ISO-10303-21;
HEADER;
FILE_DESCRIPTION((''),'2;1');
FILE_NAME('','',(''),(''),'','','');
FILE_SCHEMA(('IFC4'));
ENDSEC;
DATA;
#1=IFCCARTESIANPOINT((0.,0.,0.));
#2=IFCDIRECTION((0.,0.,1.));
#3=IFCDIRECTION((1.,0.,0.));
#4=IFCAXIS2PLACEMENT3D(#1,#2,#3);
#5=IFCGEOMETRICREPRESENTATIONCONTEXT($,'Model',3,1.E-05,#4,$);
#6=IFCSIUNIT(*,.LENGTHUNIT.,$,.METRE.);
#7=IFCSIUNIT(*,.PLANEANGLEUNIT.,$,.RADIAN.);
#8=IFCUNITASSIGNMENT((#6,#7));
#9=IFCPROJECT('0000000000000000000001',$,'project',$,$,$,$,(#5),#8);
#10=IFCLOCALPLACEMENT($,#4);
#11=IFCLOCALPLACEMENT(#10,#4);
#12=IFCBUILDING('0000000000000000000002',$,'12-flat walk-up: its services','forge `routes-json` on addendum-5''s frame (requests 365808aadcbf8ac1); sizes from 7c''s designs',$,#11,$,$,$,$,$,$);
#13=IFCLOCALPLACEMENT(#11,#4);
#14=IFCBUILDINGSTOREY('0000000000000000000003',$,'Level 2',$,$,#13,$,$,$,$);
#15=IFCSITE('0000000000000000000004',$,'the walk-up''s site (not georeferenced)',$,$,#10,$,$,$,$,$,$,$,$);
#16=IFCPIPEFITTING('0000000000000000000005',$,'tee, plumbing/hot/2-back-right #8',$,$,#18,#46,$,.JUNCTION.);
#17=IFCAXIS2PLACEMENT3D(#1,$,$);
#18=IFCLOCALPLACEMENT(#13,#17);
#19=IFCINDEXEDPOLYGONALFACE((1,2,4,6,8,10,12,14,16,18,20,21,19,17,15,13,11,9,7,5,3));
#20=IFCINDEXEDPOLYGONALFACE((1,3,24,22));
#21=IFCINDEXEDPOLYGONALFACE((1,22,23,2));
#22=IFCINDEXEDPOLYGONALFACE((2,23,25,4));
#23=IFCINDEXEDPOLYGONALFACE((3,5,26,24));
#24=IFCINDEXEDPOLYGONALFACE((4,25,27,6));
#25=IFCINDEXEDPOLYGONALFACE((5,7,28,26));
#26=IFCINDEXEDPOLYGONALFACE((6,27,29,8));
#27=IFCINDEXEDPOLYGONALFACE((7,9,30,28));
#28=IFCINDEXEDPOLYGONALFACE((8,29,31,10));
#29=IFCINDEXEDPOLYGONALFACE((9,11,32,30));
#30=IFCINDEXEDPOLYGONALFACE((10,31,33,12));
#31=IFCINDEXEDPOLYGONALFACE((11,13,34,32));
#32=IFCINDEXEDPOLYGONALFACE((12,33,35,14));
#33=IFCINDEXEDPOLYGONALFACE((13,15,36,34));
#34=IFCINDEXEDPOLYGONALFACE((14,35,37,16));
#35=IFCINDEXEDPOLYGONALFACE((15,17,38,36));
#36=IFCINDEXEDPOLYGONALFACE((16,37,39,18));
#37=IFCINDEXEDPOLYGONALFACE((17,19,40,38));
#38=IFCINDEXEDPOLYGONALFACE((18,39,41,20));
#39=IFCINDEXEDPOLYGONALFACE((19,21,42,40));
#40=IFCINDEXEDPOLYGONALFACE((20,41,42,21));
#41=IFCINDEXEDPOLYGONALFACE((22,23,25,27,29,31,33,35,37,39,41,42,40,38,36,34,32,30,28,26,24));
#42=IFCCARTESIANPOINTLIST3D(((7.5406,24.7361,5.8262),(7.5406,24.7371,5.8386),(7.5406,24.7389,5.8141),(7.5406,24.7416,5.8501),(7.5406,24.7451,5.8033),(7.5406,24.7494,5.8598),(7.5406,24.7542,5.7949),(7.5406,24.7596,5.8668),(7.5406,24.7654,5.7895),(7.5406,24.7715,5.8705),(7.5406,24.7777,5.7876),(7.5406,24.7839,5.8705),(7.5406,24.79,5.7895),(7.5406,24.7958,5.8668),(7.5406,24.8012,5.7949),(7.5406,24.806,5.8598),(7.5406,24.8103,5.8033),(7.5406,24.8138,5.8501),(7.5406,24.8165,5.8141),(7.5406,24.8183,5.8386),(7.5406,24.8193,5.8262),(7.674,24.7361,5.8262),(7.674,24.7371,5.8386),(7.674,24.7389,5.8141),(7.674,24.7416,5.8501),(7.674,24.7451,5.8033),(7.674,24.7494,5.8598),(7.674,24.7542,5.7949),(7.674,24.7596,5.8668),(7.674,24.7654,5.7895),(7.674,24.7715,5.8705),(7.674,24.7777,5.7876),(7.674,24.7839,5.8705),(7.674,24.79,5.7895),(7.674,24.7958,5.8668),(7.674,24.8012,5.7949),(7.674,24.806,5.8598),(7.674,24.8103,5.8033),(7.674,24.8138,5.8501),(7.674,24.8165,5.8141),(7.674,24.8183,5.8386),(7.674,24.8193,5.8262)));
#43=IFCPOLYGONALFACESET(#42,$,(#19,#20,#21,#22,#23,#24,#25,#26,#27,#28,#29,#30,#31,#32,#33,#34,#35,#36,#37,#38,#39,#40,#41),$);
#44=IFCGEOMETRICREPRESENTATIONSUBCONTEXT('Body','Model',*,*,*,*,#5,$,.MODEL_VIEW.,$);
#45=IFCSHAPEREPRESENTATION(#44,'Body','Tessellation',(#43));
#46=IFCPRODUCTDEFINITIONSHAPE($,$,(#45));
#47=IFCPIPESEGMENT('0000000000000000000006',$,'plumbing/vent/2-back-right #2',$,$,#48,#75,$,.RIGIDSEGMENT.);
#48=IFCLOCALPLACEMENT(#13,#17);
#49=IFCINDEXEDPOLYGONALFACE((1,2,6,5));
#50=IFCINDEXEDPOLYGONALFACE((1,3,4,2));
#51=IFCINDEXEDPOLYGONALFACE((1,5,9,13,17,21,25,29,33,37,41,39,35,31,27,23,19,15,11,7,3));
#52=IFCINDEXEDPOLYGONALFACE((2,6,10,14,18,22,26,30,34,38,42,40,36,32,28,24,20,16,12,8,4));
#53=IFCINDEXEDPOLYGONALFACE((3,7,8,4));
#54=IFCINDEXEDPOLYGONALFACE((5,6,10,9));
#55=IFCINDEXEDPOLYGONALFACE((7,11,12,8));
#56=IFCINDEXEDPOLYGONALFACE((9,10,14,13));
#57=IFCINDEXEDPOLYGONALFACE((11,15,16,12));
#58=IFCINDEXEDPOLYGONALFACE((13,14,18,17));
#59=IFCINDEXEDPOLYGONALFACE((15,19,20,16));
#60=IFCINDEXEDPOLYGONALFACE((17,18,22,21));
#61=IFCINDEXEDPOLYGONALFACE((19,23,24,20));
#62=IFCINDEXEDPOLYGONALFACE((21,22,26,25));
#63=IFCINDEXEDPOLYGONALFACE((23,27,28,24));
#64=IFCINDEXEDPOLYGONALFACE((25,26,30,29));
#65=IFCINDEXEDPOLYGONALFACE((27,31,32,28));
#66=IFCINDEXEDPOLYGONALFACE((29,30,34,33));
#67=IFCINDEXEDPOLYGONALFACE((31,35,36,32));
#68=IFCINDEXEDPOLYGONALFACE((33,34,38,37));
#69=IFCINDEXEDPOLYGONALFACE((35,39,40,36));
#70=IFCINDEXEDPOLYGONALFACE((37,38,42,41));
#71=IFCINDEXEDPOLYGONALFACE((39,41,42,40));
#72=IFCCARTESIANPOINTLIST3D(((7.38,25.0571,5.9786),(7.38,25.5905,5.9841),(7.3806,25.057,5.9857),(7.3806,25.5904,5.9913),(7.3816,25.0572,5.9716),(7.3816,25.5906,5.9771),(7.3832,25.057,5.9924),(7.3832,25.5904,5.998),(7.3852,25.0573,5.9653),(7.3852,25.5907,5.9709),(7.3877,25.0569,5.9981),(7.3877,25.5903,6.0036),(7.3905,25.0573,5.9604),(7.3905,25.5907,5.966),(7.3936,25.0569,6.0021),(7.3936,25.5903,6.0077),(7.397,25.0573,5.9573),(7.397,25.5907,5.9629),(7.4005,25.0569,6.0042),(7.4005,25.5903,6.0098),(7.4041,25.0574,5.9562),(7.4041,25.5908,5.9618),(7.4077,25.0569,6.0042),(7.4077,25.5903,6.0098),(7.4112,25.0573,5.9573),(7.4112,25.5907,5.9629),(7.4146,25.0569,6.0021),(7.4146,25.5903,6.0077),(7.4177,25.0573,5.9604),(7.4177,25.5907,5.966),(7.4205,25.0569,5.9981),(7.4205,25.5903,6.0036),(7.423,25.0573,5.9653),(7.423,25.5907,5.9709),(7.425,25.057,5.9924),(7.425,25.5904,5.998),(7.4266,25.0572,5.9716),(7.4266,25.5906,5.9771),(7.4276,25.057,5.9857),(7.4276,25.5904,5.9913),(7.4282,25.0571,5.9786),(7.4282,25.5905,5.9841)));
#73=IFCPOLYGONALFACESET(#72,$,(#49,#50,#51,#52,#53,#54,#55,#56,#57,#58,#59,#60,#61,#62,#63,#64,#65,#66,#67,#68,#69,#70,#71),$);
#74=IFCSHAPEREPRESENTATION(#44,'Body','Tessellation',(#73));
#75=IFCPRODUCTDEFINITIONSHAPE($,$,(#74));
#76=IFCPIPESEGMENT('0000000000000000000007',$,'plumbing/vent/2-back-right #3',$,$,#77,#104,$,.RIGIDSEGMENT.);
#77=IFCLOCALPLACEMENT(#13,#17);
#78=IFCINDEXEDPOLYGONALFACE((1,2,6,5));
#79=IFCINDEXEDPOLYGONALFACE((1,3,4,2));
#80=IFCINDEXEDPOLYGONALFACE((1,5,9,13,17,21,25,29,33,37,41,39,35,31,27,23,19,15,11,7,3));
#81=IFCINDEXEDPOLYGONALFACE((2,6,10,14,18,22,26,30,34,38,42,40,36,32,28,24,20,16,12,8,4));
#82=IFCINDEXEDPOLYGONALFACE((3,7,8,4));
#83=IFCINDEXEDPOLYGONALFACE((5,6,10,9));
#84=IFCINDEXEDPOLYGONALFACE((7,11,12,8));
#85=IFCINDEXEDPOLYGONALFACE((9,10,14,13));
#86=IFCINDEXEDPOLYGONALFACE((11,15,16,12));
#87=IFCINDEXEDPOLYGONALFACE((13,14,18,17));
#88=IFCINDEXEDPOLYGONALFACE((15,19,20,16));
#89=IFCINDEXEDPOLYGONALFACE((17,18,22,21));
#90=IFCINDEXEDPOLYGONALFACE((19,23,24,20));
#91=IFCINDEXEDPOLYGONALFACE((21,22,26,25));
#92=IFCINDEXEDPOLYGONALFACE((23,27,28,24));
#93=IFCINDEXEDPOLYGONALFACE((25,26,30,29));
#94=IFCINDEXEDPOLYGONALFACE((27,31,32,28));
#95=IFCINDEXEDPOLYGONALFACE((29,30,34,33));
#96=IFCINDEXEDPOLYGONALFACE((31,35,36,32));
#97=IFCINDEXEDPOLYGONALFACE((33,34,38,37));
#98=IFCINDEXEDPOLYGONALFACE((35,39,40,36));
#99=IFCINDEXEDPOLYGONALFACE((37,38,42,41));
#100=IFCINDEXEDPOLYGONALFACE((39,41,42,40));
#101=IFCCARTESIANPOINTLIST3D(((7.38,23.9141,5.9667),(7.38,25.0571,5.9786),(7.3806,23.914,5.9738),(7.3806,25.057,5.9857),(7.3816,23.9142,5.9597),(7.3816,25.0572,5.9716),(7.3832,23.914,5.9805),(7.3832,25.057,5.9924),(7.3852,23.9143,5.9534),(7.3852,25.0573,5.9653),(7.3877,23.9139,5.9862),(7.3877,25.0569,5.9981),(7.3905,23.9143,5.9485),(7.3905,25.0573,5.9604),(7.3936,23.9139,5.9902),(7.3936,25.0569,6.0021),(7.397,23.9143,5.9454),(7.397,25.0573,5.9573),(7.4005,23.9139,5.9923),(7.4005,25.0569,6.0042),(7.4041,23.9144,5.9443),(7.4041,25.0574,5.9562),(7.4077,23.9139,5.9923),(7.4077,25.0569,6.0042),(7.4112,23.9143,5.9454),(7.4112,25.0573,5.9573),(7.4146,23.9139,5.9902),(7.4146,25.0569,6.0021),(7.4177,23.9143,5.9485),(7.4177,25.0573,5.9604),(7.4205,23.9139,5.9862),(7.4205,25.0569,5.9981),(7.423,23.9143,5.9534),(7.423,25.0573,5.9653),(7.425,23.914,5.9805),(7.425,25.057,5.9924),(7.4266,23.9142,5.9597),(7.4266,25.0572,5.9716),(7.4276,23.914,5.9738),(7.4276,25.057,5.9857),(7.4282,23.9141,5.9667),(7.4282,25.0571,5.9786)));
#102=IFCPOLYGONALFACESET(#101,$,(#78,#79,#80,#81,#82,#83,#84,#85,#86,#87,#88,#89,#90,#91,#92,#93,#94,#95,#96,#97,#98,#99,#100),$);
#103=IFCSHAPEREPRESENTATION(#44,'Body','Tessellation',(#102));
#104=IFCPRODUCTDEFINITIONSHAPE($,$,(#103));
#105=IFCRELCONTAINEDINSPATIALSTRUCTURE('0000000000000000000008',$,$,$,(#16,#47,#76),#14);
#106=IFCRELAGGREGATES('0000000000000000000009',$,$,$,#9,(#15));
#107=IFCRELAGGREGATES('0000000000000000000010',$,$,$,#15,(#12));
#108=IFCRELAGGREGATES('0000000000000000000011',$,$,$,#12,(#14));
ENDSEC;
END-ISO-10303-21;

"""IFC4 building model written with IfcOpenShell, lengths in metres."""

from ifc_helpers import new_model, entity, si_unit, frame, origin_with_axes, place, context, subcontext, project, spatial, element, save


model = new_model("IFC4")

# Units and contexts
model_context = context("Model", 3, precision=1e-05, world=origin_with_axes())
body_context = subcontext(model_context, "Body", "Model", "MODEL_VIEW")
ifc_project = project(units=[si_unit("LENGTHUNIT", "METRE"), si_unit("PLANEANGLEUNIT", "RADIAN")], contexts=[model_context])

# Site, building, storey
site_placement = place(None, origin_with_axes())
site = spatial("IfcSite", under=ifc_project, at=site_placement, Name="the walk-up's site (not georeferenced)")
building_placement = place(site_placement, origin_with_axes())
building = spatial("IfcBuilding", under=site, at=building_placement, Name="12-flat walk-up: its services", Description="forge `routes-json` on addendum-5's frame (requests 365808aadcbf8ac1); sizes from 7c's designs")
storey_placement = place(building_placement, origin_with_axes())
storey = spatial("IfcBuildingStorey", under=building, at=storey_placement, Name="Level 2")

# Pipe fitting
pipe_fitting_1_placement = place(storey_placement, frame((7.674, 24.7777, 5.8293), z_axis=(0.0, 0.0, 1.0), x_axis=(1.0, 0.0, 0.0)))
element("IfcPipeFitting", 1, at=pipe_fitting_1_placement, inside=storey, Name="tee, plumbing/hot/2-back-right #8", PredefinedType="JUNCTION", context=body_context, shape_type="AdvancedSweptSolid", body=[
    entity("IfcSweptDiskSolid", entity("IfcPolyline", [entity("IfcCartesianPoint", [0.0, 0.0, 0.0]), entity("IfcCartesianPoint", [-0.1334, 0.0, 0.0])]), 0.0417),
])

# Pipe segments
pipe_segment_1_placement = place(storey_placement, frame((7.4041, 25.5905, 5.9859), z_axis=(0.0, 0.0, 1.0), x_axis=(1.0, 0.0, 0.0)))
element("IfcPipeSegment", 2, at=pipe_segment_1_placement, inside=storey, Name="plumbing/vent/2-back-right #2", PredefinedType="RIGIDSEGMENT", context=body_context, shape_type="AdvancedSweptSolid", body=[
    entity("IfcSweptDiskSolid", entity("IfcPolyline", [entity("IfcCartesianPoint", [0.0, 0.0, 0.0]), entity("IfcCartesianPoint", [0.0, -0.5334, -0.0056])]), 0.0241),
])
pipe_segment_2_placement = place(storey_placement, frame((7.4041, 25.0571, 5.9804), z_axis=(0.0, 0.0, 1.0), x_axis=(1.0, 0.0, 0.0)))
element("IfcPipeSegment", 3, at=pipe_segment_2_placement, inside=storey, Name="plumbing/vent/2-back-right #3", PredefinedType="RIGIDSEGMENT", context=body_context, shape_type="AdvancedSweptSolid", body=[
    entity("IfcSweptDiskSolid", entity("IfcPolyline", [entity("IfcCartesianPoint", [0.0, 0.0, 0.0]), entity("IfcCartesianPoint", [0.0, -1.143, -0.0119])]), 0.0241),
])

save(model, "model.ifc")
